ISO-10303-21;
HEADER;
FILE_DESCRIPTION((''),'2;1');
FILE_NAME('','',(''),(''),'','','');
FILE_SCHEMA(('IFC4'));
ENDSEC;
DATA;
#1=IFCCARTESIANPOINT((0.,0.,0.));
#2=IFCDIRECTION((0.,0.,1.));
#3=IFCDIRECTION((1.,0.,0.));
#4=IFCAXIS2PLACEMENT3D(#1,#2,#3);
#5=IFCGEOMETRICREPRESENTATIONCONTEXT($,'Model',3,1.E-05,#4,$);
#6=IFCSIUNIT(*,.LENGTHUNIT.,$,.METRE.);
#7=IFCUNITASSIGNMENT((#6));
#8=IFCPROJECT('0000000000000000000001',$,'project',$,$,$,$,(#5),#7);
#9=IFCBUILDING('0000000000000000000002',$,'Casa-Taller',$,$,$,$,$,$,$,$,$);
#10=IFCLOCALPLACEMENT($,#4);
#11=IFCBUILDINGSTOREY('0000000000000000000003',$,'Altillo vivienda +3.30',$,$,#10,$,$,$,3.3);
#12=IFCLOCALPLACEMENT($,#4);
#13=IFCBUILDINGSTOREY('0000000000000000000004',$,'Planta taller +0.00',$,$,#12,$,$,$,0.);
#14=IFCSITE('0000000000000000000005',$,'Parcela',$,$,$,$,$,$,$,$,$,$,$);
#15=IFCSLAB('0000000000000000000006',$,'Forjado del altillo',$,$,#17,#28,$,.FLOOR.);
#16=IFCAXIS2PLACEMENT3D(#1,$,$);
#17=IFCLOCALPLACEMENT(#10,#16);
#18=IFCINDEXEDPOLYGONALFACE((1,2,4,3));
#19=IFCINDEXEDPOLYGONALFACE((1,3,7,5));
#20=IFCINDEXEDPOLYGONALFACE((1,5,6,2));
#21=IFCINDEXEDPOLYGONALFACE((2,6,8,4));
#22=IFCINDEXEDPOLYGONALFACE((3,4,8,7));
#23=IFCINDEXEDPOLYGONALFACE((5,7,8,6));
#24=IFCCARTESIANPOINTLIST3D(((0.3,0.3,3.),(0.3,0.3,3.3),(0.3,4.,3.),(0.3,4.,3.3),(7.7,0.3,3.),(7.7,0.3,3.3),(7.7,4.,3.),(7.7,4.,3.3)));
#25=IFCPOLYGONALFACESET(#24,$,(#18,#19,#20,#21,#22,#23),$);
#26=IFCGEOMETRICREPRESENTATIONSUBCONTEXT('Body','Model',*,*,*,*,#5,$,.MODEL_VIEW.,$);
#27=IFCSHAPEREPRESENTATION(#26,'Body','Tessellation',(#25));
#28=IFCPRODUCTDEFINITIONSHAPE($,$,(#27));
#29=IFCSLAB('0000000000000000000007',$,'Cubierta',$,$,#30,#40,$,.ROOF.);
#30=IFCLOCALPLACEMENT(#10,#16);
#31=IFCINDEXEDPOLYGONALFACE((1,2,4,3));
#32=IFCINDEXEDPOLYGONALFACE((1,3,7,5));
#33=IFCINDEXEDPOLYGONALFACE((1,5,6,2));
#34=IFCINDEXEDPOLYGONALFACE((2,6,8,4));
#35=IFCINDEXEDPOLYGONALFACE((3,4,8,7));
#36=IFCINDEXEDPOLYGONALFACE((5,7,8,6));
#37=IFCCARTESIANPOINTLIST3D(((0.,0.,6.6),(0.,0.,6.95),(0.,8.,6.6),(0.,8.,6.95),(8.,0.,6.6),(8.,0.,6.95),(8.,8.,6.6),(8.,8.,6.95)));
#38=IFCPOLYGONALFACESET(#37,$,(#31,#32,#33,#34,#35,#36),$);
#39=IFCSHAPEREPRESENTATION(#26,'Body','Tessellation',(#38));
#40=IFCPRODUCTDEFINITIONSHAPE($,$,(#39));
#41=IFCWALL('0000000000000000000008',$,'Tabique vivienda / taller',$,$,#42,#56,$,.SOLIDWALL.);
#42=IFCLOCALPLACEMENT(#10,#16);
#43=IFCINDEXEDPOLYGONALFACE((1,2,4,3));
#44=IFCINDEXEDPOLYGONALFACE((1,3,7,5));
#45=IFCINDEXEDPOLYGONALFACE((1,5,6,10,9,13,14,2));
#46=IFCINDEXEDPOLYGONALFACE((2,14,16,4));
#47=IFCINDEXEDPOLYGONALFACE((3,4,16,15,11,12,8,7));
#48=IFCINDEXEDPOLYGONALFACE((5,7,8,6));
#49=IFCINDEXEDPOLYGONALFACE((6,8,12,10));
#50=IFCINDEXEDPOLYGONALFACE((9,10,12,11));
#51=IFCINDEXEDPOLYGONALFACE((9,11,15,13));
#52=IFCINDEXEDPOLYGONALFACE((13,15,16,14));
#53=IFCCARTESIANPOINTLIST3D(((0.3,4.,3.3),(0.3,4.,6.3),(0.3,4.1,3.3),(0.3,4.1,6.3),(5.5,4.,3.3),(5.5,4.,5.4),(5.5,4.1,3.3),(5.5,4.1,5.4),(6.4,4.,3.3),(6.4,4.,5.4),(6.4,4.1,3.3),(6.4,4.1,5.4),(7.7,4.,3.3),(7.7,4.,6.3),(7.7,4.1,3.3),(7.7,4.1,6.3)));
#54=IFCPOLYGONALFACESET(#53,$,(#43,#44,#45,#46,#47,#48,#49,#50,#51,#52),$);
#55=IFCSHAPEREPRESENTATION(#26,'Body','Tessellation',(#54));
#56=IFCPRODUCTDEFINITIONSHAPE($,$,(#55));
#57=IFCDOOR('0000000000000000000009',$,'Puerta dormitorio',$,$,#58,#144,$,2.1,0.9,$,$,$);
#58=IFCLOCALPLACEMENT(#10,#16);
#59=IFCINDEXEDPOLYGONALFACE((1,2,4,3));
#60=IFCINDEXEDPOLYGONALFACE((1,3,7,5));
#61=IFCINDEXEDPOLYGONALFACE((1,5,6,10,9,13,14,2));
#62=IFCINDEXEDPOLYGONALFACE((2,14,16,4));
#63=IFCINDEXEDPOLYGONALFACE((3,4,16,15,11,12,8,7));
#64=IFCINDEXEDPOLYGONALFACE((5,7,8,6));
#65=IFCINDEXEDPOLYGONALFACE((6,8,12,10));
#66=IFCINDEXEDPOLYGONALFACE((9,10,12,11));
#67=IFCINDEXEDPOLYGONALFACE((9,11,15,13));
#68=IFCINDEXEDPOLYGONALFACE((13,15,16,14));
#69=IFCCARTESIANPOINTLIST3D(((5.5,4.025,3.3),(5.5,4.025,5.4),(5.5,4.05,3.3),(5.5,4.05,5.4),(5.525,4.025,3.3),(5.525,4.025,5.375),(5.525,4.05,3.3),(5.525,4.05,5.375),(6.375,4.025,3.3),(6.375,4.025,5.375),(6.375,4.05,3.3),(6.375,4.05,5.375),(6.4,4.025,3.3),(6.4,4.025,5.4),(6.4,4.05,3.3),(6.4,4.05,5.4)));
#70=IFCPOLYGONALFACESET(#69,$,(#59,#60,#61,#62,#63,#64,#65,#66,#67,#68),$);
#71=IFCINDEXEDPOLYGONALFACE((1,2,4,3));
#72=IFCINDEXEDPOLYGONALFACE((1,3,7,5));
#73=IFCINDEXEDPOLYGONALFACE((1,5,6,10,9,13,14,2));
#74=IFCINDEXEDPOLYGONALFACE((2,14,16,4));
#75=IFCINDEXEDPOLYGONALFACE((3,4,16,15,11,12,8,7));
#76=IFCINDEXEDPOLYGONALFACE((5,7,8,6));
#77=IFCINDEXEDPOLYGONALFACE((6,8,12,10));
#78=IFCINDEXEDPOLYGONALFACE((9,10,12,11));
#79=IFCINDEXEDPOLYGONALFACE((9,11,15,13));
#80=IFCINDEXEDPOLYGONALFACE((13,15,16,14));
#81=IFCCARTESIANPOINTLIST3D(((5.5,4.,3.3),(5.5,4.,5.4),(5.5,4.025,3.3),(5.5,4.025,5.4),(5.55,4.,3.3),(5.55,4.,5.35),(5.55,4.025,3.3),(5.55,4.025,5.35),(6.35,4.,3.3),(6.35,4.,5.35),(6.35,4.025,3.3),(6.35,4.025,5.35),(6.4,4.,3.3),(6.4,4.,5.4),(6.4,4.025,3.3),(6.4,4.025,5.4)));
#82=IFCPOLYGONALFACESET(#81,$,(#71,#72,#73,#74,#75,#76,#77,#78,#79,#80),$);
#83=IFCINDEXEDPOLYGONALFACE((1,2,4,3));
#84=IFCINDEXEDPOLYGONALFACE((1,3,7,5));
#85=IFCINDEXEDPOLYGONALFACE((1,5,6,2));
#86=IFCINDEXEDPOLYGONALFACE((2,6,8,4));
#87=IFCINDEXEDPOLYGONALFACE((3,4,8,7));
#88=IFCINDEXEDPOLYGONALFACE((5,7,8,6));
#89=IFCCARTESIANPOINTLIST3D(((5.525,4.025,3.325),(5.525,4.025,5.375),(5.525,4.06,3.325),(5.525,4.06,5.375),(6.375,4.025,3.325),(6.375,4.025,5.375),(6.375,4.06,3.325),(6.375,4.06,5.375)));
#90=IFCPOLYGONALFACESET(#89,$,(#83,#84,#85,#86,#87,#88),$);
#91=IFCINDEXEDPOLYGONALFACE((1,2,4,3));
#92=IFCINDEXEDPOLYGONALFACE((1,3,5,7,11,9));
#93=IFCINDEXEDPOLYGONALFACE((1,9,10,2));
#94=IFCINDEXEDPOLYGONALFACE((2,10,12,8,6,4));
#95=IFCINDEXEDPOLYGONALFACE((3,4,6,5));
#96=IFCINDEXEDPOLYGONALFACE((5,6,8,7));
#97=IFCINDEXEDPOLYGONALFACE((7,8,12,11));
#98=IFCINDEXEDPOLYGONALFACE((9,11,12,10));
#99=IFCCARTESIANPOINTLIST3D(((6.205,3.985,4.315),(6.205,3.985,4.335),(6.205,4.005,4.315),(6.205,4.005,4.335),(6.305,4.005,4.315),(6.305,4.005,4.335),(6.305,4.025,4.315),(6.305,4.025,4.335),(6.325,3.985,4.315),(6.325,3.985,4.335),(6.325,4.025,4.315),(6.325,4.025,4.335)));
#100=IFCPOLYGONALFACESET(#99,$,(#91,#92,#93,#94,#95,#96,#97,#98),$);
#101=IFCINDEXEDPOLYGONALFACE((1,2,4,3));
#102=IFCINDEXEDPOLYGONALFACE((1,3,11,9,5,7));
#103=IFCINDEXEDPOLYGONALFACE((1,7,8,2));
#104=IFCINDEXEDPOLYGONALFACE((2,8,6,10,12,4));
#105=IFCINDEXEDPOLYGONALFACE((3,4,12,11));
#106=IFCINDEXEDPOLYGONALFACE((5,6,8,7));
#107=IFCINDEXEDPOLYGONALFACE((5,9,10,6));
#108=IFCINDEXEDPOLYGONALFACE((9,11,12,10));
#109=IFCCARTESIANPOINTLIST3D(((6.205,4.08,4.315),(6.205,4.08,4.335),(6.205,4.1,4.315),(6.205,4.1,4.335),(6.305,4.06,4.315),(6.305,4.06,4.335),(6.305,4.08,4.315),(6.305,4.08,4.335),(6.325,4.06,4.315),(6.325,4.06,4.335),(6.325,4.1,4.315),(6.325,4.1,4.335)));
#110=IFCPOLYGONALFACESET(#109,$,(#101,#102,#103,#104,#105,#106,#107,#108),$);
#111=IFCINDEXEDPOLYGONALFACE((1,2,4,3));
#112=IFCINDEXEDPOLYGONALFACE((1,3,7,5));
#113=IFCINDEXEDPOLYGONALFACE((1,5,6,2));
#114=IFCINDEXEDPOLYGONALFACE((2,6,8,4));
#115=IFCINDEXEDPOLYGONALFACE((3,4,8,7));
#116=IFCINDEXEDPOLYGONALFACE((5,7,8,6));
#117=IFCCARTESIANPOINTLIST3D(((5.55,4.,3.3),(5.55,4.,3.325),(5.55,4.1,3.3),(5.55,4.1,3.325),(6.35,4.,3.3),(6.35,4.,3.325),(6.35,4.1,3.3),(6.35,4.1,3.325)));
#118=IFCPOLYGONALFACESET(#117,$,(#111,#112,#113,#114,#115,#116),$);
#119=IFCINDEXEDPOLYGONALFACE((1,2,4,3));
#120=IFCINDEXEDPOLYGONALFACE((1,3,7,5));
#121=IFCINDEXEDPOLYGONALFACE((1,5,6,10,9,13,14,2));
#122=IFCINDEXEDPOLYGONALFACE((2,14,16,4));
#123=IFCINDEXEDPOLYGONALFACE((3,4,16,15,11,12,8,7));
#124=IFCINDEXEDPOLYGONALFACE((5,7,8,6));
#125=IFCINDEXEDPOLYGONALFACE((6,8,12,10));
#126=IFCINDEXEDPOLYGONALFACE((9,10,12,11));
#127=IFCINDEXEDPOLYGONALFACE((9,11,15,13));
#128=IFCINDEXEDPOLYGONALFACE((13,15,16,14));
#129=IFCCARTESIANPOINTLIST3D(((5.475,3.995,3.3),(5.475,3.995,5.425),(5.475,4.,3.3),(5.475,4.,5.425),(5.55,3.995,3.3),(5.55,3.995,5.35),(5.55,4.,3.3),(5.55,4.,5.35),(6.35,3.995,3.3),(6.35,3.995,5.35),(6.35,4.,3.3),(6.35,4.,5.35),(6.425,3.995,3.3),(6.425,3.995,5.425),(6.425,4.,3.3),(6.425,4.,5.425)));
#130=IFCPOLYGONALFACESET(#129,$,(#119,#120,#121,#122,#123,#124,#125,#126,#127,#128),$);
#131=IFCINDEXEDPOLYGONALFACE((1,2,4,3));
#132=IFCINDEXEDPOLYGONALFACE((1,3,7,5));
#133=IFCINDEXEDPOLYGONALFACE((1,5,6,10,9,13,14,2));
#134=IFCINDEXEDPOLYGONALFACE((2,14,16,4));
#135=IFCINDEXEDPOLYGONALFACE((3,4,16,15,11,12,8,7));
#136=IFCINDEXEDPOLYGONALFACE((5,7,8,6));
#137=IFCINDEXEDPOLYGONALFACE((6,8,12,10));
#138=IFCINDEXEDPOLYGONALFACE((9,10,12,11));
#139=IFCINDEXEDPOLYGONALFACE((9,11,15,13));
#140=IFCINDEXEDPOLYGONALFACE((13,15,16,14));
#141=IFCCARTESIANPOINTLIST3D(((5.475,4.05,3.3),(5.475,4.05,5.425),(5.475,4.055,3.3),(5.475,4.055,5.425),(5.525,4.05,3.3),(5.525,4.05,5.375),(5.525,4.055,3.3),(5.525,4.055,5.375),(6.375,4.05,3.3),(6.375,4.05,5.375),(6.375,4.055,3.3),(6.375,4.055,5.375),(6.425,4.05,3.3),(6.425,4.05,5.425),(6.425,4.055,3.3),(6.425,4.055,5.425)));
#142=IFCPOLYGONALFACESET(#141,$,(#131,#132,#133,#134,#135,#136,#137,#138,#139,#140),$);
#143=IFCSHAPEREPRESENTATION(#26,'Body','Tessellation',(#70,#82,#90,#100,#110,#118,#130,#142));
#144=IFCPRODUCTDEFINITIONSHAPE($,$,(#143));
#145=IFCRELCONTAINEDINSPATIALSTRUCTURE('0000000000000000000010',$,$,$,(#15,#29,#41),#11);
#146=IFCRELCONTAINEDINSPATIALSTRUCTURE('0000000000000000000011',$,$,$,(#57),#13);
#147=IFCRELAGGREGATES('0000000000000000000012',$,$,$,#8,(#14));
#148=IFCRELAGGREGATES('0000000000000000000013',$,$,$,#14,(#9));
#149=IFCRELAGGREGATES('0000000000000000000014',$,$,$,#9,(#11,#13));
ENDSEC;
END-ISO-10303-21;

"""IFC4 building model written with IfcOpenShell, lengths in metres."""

from ifc_helpers import new_model, si_unit, frame, origin_with_axes, place, context, subcontext, project, spatial, line, indexed_curve, outline, extrude, element, fill, save


model = new_model("IFC4")

# Units and contexts
model_context = context("Model", 3, precision=1e-05, world=origin_with_axes())
body_context = subcontext(model_context, "Body", "Model", "MODEL_VIEW")
ifc_project = project(units=[si_unit("LENGTHUNIT", "METRE")], contexts=[model_context])

# Site, building, storey
site = spatial("IfcSite", under=ifc_project, Name="Parcela")
building = spatial("IfcBuilding", under=site, Name="Casa-Taller")
storey_1_placement = place(None, origin_with_axes())
storey_1 = spatial("IfcBuildingStorey", under=building, at=storey_1_placement, Name="Altillo vivienda +3.30", Elevation=3.3)

# Slabs
slab_1_placement = place(storey_1_placement, frame((0.3, 0.3, 3.0), z_axis=(0.0, 0.0, 1.0), x_axis=(1.0, 0.0, 0.0)))
element("IfcSlab", 1, at=slab_1_placement, inside=storey_1, Name="Forjado del altillo", PredefinedType="FLOOR", context=body_context, shape_type="SweptSolid", body=[
    extrude(outline(indexed_curve([(0.0, 0.0), (7.4, 0.0), (7.4, 3.7), (0.0, 3.7)])), None, (0.0, 0.0, 1.0), 0.3),
])
slab_2_placement = place(storey_1_placement, frame((0.0, 0.0, 6.6), z_axis=(0.0, 0.0, 1.0), x_axis=(1.0, 0.0, 0.0)))
element("IfcSlab", 2, at=slab_2_placement, inside=storey_1, Name="Cubierta", PredefinedType="ROOF", context=body_context, shape_type="SweptSolid", body=[
    extrude(outline(indexed_curve([(0.0, 0.0), (8.0, 0.0), (8.0, 8.0), (0.0, 8.0)])), None, (0.0, 0.0, 1.0), 0.35),
])

# Wall, opening
wall_placement = place(storey_1_placement, frame((0.3, 4.0, 3.3), z_axis=(0.0, 0.0, 1.0), x_axis=(1.0, 0.0, 0.0)))
wall = element("IfcWall", 3, at=wall_placement, inside=storey_1, Name="Tabique vivienda / taller", PredefinedType="SOLIDWALL", context=body_context, shape_type="SweptSolid", body=[
    extrude(outline(indexed_curve([(0.0, 0.0), (0.0, 0.1), (7.4, 0.1), (7.4, 0.0), (0.0, 0.0)], self_intersect=False)), origin_with_axes(), (0.0, 0.0, 1.0), 3.0),
])
opening_placement = place(wall_placement, frame((5.2, -0.1, 0.0), z_axis=(0.0, 0.0, 1.0), x_axis=(1.0, 0.0, 0.0)))
opening = element("IfcOpeningElement", 4, at=opening_placement, cuts=wall, context=body_context, shape_type="SweptSolid", body=[
    extrude(outline(indexed_curve([(0.0, 0.0), (0.0, 0.3), (0.9, 0.3), (0.9, 0.0), (0.0, 0.0)], self_intersect=False)), origin_with_axes(), (0.0, 0.0, 1.0), 2.1),
])

# Shared definitions
storey_2_placement = place(None, origin_with_axes())
storey_2 = spatial("IfcBuildingStorey", under=building, at=storey_2_placement, Name="Planta taller +0.00", Elevation=0.0)

# Door
door_placement = place(opening_placement, frame((0.0, 0.1, 0.0), z_axis=(0.0, 0.0, 1.0), x_axis=(1.0, 0.0, 0.0)))
door = element("IfcDoor", 5, at=door_placement, inside=storey_2, Name="Puerta dormitorio", OverallHeight=2.1, OverallWidth=0.9, context=body_context, shape_type="SweptSolid", body=[
    extrude(outline(indexed_curve([(0.0, 0.0), (0.0, 2.1), (0.9, 2.1), (0.9, 0.0), (0.875, 0.0), (0.875, 2.075), (0.025, 2.075), (0.025, 0.0)], segments=[line(1, 2, 3, 4, 5, 6, 7, 8, 1)])), frame((0.0, 0.025, 0.0), z_axis=(0.0, -1.0, 0.0), x_axis=(1.0, 0.0, 0.0)), (0.0, 0.0, -1.0), 0.025),
    extrude(outline(indexed_curve([(0.0, 0.0), (0.0, 2.1), (0.9, 2.1), (0.9, 0.0), (0.85, 0.0), (0.85, 2.05), (0.05, 2.05), (0.05, 0.0)], segments=[line(1, 2, 3, 4, 5, 6, 7, 8, 1)])), frame((0.0, 0.0, 0.0), z_axis=(0.0, -1.0, 0.0), x_axis=(1.0, 0.0, 0.0)), (0.0, 0.0, -1.0), 0.025),
    extrude(outline(indexed_curve([(0.0, 0.0), (0.85, 0.0), (0.85, 0.035), (0.0, 0.035)], segments=[line(1, 2, 3, 4, 1)])), frame((0.025, 0.025, 0.025), z_axis=(0.0, 0.0, 1.0), x_axis=(1.0, 0.0, 0.0)), (0.0, 0.0, 1.0), 2.05),
    extrude(outline(indexed_curve([(0.0, 0.0), (0.0, -0.04), (-0.12, -0.04), (-0.12, -0.02), (-0.02, -0.02), (-0.02, 0.0)], segments=[line(1, 2, 3, 4, 5, 6, 1)])), frame((0.825, 0.025, 1.015), z_axis=(0.0, 0.0, 1.0), x_axis=(1.0, 0.0, 0.0)), (0.0, 0.0, 1.0), 0.02),
    extrude(outline(indexed_curve([(0.0, 0.0), (0.0, 0.04), (-0.12, 0.04), (-0.12, 0.02), (-0.02, 0.02), (-0.02, 0.0)], segments=[line(1, 2, 3, 4, 5, 6, 1)])), frame((0.825, 0.06, 1.015), z_axis=(0.0, 0.0, 1.0), x_axis=(1.0, 0.0, 0.0)), (0.0, 0.0, 1.0), 0.02),
    extrude(outline(indexed_curve([(0.0, 0.0), (0.8, 0.0), (0.8, 0.1), (0.0, 0.1)], segments=[line(1, 2, 3, 4, 1)])), frame((0.05, 0.0, 0.0), z_axis=(0.0, 0.0, 1.0), x_axis=(1.0, 0.0, 0.0)), (0.0, 0.0, 1.0), 0.025),
    extrude(outline(indexed_curve([(0.0, 0.0), (0.0, 2.125), (0.95, 2.125), (0.95, 0.0), (0.875, 0.0), (0.875, 2.05), (0.075, 2.05), (0.075, 0.0)], segments=[line(1, 2, 3, 4, 5, 6, 7, 8, 1)])), frame((-0.025, -0.005, 0.0), z_axis=(0.0, -1.0, 0.0), x_axis=(1.0, 0.0, 0.0)), (0.0, 0.0, -1.0), 0.005),
    extrude(outline(indexed_curve([(0.0, 0.0), (0.0, 2.125), (0.95, 2.125), (0.95, 0.0), (0.9, 0.0), (0.9, 2.075), (0.05, 2.075), (0.05, 0.0)], segments=[line(1, 2, 3, 4, 5, 6, 7, 8, 1)])), frame((-0.025, 0.05, 0.0), z_axis=(0.0, -1.0, 0.0), x_axis=(1.0, 0.0, 0.0)), (0.0, 0.0, -1.0), 0.005),
])
fill(opening, door)

save(model, "model.ifc")
